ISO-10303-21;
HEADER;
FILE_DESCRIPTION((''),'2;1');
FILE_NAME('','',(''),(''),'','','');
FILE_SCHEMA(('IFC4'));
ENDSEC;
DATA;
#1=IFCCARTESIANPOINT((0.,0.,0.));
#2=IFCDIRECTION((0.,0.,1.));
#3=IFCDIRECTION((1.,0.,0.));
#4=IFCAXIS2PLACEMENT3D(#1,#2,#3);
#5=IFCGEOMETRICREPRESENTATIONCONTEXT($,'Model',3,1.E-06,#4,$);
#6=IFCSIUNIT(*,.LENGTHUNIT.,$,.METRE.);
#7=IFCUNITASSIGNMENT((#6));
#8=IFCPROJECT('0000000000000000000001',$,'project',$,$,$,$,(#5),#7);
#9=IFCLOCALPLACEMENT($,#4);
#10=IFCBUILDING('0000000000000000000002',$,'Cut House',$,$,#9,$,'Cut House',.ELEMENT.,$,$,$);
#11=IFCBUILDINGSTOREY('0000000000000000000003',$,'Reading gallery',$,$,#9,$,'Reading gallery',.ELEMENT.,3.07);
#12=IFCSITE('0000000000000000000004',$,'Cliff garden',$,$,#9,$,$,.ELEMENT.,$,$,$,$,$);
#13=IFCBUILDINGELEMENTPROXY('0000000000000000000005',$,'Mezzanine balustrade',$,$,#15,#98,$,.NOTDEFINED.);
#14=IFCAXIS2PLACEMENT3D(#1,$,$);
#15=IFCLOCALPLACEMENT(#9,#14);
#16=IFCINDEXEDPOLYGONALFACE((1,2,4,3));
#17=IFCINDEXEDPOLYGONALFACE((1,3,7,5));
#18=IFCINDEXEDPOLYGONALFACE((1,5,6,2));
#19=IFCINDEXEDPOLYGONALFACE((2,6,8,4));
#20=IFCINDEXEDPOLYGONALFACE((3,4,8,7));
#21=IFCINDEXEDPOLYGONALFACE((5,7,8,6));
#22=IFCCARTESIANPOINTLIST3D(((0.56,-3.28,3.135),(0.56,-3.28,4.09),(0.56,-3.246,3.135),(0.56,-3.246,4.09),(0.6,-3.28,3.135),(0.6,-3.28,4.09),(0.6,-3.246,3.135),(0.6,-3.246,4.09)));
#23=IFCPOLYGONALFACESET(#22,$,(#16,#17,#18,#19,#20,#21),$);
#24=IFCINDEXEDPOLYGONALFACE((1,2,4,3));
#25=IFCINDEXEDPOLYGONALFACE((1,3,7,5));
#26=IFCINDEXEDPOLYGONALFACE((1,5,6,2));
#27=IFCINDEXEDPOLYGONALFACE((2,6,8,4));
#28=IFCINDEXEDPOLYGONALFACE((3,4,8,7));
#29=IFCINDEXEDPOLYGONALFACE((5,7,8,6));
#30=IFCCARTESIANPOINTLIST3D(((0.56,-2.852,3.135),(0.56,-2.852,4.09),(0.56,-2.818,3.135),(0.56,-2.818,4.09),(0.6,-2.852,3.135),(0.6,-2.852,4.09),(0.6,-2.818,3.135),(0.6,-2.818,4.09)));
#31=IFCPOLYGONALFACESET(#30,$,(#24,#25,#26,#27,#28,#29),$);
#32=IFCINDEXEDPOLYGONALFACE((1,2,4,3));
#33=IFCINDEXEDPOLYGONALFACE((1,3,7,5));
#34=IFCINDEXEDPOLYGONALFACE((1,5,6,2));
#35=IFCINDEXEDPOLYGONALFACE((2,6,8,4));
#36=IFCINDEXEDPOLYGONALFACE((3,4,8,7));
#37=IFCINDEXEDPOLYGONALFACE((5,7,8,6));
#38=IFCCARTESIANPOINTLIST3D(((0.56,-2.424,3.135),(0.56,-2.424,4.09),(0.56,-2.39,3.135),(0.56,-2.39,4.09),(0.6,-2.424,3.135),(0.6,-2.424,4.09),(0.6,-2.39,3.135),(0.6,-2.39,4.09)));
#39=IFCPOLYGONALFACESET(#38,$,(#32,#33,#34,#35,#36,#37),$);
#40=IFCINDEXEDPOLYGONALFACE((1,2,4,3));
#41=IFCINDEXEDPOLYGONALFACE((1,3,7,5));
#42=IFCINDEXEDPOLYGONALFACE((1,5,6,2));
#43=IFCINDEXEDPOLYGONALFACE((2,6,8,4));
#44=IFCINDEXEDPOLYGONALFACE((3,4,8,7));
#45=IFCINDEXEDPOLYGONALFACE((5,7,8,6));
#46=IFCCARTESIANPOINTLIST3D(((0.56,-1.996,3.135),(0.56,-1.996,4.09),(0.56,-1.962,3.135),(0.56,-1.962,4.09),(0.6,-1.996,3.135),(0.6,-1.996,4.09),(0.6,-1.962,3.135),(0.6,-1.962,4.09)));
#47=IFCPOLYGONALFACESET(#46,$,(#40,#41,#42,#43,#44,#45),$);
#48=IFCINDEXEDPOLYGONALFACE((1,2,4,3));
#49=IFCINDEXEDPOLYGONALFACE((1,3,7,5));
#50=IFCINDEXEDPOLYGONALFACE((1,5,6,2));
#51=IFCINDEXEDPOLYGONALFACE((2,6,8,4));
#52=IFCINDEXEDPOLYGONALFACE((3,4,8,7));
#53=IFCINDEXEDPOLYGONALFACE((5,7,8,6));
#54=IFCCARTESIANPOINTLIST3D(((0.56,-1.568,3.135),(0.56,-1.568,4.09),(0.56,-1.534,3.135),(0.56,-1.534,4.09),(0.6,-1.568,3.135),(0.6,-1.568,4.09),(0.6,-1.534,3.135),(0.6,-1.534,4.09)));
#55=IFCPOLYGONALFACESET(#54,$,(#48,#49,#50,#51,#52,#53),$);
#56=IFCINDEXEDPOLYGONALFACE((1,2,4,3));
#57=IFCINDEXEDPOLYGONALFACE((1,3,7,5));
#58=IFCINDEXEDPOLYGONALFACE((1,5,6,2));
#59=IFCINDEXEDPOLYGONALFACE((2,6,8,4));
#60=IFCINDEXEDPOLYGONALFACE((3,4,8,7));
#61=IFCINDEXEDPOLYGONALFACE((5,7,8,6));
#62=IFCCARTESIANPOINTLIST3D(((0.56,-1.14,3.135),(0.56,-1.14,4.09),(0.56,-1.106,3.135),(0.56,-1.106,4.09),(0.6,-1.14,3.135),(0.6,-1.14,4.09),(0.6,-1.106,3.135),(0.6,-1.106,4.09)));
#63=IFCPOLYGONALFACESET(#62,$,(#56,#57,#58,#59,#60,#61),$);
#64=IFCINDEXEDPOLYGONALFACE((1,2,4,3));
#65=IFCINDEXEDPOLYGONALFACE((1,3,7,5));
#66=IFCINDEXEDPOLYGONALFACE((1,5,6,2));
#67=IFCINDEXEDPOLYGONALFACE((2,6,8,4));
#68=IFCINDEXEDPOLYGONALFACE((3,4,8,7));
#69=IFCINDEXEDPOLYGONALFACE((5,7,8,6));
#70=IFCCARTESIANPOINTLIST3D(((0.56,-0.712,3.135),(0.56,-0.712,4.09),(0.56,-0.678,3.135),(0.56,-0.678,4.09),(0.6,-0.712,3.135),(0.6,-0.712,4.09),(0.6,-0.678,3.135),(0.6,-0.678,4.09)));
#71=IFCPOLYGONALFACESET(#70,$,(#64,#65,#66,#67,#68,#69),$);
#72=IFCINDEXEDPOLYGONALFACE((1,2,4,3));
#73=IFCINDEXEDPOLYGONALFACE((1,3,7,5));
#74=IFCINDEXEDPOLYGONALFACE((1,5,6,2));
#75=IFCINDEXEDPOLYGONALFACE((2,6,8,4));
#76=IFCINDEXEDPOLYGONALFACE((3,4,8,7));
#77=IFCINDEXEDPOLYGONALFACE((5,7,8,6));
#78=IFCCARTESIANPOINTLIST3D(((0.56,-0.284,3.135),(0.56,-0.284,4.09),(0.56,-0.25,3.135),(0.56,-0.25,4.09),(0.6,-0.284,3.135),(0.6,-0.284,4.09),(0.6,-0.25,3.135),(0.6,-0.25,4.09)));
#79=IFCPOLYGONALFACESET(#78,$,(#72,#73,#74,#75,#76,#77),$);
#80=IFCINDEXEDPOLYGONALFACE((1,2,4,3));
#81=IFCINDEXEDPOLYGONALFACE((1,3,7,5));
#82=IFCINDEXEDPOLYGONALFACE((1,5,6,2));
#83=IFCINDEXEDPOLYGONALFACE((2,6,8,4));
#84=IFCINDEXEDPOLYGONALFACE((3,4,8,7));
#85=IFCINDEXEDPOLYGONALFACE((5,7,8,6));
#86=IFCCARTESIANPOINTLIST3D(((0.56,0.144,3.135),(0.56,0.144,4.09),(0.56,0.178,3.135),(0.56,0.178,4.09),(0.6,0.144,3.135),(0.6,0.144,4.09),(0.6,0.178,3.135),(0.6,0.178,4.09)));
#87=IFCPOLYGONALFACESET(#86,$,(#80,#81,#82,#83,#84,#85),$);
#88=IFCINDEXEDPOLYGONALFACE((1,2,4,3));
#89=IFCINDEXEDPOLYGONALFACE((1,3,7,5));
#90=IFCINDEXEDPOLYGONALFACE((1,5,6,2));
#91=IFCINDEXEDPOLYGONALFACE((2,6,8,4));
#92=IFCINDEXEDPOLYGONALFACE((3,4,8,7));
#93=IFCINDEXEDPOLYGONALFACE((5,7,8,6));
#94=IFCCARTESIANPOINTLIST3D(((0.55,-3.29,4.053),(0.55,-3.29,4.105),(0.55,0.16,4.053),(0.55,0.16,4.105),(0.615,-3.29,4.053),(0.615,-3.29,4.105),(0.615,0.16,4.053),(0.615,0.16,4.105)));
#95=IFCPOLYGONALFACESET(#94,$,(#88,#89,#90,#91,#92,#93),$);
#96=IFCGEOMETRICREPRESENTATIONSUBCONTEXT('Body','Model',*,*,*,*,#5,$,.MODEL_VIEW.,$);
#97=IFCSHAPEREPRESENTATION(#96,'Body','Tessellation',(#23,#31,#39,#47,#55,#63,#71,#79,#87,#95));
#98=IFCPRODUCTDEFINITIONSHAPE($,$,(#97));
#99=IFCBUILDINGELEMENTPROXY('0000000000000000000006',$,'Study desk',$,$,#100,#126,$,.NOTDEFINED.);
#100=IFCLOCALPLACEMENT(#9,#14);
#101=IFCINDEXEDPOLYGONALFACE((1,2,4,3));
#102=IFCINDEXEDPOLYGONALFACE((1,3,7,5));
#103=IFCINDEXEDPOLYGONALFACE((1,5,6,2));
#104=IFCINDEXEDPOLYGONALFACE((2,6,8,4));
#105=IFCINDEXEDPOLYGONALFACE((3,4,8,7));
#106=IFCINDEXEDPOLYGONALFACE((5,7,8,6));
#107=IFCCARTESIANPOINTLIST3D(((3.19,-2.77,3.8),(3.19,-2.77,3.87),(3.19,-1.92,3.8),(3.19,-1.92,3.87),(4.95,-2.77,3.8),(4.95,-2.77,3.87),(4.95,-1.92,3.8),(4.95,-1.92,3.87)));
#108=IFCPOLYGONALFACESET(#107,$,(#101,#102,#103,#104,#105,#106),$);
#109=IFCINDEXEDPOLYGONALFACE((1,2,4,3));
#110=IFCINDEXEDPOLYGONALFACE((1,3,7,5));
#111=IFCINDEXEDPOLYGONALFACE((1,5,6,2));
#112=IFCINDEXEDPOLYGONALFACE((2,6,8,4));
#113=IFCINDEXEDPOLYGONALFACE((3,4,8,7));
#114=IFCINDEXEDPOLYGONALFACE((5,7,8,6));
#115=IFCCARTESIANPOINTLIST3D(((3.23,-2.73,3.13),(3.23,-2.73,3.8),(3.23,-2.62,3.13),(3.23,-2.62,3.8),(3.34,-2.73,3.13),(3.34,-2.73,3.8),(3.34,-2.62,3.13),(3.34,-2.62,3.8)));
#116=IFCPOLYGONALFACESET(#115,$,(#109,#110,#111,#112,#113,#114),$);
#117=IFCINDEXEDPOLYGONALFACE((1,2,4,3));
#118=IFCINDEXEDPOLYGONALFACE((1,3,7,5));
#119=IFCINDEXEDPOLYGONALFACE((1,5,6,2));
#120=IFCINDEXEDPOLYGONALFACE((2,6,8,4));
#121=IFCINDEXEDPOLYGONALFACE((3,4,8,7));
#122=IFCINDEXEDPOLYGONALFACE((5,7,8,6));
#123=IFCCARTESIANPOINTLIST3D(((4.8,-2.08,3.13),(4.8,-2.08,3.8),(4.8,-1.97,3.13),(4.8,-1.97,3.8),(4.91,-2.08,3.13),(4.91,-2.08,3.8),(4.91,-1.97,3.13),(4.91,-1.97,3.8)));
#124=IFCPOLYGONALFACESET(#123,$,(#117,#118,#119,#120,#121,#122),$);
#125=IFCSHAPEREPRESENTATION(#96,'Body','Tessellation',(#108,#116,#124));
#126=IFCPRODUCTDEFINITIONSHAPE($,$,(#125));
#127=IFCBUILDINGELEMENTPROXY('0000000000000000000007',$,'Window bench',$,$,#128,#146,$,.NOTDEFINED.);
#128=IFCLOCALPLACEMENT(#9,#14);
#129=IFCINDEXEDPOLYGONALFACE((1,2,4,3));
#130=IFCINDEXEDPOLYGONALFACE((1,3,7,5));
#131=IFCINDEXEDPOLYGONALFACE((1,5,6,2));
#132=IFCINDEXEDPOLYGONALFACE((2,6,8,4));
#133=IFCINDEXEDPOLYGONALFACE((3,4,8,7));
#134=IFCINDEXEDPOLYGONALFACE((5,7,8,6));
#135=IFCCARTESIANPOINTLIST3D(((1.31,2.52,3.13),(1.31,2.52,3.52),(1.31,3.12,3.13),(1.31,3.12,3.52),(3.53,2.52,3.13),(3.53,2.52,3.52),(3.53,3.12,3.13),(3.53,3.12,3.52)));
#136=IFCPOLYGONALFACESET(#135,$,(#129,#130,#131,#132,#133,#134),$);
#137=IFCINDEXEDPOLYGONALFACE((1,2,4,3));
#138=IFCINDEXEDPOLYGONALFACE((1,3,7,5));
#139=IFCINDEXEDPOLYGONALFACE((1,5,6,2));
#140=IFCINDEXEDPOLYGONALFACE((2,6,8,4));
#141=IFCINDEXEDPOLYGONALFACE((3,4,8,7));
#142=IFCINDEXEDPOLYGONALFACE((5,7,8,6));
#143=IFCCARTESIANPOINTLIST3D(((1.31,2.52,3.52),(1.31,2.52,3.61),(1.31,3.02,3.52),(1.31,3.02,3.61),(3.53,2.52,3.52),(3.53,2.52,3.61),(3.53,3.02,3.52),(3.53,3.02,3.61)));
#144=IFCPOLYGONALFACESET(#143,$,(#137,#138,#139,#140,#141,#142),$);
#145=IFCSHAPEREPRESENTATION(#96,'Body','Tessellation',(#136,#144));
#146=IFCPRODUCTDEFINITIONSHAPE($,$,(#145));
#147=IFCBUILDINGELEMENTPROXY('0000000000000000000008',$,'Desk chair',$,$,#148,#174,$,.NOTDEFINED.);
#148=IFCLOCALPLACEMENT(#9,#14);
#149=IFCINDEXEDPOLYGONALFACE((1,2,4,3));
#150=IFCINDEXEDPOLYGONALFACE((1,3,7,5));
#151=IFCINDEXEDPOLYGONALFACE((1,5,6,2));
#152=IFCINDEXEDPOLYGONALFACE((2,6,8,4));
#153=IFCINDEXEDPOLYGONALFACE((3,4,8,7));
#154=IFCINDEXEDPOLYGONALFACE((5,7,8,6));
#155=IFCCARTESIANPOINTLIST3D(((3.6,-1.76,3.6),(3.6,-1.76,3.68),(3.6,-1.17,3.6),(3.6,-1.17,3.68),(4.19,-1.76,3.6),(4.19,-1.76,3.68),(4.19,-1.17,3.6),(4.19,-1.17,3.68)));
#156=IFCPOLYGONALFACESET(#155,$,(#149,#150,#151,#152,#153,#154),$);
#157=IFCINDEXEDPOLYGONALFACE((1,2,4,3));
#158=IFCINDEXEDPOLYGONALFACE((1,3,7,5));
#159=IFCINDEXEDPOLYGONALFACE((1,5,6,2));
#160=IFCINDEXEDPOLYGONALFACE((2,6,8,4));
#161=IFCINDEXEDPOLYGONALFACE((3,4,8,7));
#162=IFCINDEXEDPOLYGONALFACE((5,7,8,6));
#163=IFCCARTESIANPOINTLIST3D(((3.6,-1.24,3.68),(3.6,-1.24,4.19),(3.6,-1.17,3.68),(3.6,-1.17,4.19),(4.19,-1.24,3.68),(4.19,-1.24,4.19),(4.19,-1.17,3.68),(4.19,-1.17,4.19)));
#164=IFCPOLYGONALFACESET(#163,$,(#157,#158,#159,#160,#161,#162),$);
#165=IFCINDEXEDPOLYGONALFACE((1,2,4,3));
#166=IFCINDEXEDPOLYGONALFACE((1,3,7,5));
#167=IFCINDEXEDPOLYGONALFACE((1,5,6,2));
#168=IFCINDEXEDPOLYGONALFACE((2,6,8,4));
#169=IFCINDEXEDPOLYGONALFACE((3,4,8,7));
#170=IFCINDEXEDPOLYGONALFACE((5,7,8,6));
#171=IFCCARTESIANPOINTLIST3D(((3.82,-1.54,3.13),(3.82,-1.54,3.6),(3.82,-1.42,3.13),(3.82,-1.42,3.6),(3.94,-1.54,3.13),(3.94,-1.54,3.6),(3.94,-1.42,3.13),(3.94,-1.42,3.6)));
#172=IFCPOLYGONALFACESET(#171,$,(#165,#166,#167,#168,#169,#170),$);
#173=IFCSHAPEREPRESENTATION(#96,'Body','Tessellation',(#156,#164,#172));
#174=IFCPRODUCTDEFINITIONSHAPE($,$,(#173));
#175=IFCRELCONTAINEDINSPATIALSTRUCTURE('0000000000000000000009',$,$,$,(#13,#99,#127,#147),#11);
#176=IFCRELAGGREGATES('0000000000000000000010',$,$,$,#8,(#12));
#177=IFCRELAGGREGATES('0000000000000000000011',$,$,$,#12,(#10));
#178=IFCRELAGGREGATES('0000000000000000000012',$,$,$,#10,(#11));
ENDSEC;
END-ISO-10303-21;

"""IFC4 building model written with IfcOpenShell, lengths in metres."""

from ifc_helpers import new_model, si_unit, frame, origin_with_axes, place, context, subcontext, project, spatial, polyline, outline, extrude, element, save


model = new_model("IFC4")

# Units and contexts
model_context = context("Model", 3, precision=1e-06, world=origin_with_axes())
body_context = subcontext(model_context, "Body", "Model", "MODEL_VIEW")
ifc_project = project(units=[si_unit("LENGTHUNIT", "METRE")], contexts=[model_context])

# Site, building, storey
placement = place(None, origin_with_axes())
site = spatial("IfcSite", under=ifc_project, at=placement, Name="Cliff garden", CompositionType="ELEMENT")
building = spatial("IfcBuilding", under=site, at=placement, Name="Cut House", LongName="Cut House", CompositionType="ELEMENT")
storey = spatial("IfcBuildingStorey", under=building, at=placement, Name="Reading gallery", LongName="Reading gallery", CompositionType="ELEMENT", Elevation=3.07)

# Building element proxies
element("IfcBuildingElementProxy", 1, at=placement, inside=storey, Name="Mezzanine balustrade", PredefinedType="NOTDEFINED", context=body_context, shape_type="SweptSolid", body=[
    extrude(outline(polyline([(0.0, 0.0), (0.04, 0.0), (0.04, 0.034), (0.0, 0.034), (0.0, 0.0)])), frame((0.56, -3.28, 3.135), z_axis=(0.0, 0.0, 1.0), x_axis=(1.0, 0.0, 0.0)), (0.0, 0.0, 1.0), 0.955),
    extrude(outline(polyline([(0.0, 0.0), (0.04, 0.0), (0.04, 0.034), (0.0, 0.034), (0.0, 0.0)])), frame((0.56, -2.852, 3.135), z_axis=(0.0, 0.0, 1.0), x_axis=(1.0, 0.0, 0.0)), (0.0, 0.0, 1.0), 0.955),
    extrude(outline(polyline([(0.0, 0.0), (0.04, 0.0), (0.04, 0.034), (0.0, 0.034), (0.0, 0.0)])), frame((0.56, -2.424, 3.135), z_axis=(0.0, 0.0, 1.0), x_axis=(1.0, 0.0, 0.0)), (0.0, 0.0, 1.0), 0.955),
    extrude(outline(polyline([(0.0, 0.0), (0.04, 0.0), (0.04, 0.034), (0.0, 0.034), (0.0, 0.0)])), frame((0.56, -1.996, 3.135), z_axis=(0.0, 0.0, 1.0), x_axis=(1.0, 0.0, 0.0)), (0.0, 0.0, 1.0), 0.955),
    extrude(outline(polyline([(0.0, 0.0), (0.04, 0.0), (0.04, 0.034), (0.0, 0.034), (0.0, 0.0)])), frame((0.56, -1.568, 3.135), z_axis=(0.0, 0.0, 1.0), x_axis=(1.0, 0.0, 0.0)), (0.0, 0.0, 1.0), 0.955),
    extrude(outline(polyline([(0.0, 0.0), (0.04, 0.0), (0.04, 0.034), (0.0, 0.034), (0.0, 0.0)])), frame((0.56, -1.14, 3.135), z_axis=(0.0, 0.0, 1.0), x_axis=(1.0, 0.0, 0.0)), (0.0, 0.0, 1.0), 0.955),
    extrude(outline(polyline([(0.0, 0.0), (0.04, 0.0), (0.04, 0.034), (0.0, 0.034), (0.0, 0.0)])), frame((0.56, -0.712, 3.135), z_axis=(0.0, 0.0, 1.0), x_axis=(1.0, 0.0, 0.0)), (0.0, 0.0, 1.0), 0.955),
    extrude(outline(polyline([(0.0, 0.0), (0.04, 0.0), (0.04, 0.034), (0.0, 0.034), (0.0, 0.0)])), frame((0.56, -0.284, 3.135), z_axis=(0.0, 0.0, 1.0), x_axis=(1.0, 0.0, 0.0)), (0.0, 0.0, 1.0), 0.955),
    extrude(outline(polyline([(0.0, 0.0), (0.04, 0.0), (0.04, 0.034), (0.0, 0.034), (0.0, 0.0)])), frame((0.56, 0.144, 3.135), z_axis=(0.0, 0.0, 1.0), x_axis=(1.0, 0.0, 0.0)), (0.0, 0.0, 1.0), 0.955),
    extrude(outline(polyline([(0.0, 0.0), (0.065, 0.0), (0.065, 3.45), (0.0, 3.45), (0.0, 0.0)])), frame((0.55, -3.29, 4.053), z_axis=(0.0, 0.0, 1.0), x_axis=(1.0, 0.0, 0.0)), (0.0, 0.0, 1.0), 0.052),
])
element("IfcBuildingElementProxy", 2, at=placement, inside=storey, Name="Study desk", PredefinedType="NOTDEFINED", context=body_context, shape_type="SweptSolid", body=[
    extrude(outline(polyline([(0.0, 0.0), (1.76, 0.0), (1.76, 0.85), (0.0, 0.85), (0.0, 0.0)])), frame((3.19, -2.77, 3.8), z_axis=(0.0, 0.0, 1.0), x_axis=(1.0, 0.0, 0.0)), (0.0, 0.0, 1.0), 0.07),
    extrude(outline(polyline([(0.0, 0.0), (0.11, 0.0), (0.11, 0.11), (0.0, 0.11), (0.0, 0.0)])), frame((3.23, -2.73, 3.13), z_axis=(0.0, 0.0, 1.0), x_axis=(1.0, 0.0, 0.0)), (0.0, 0.0, 1.0), 0.67),
    extrude(outline(polyline([(0.0, 0.0), (0.11, 0.0), (0.11, 0.11), (0.0, 0.11), (0.0, 0.0)])), frame((4.8, -2.08, 3.13), z_axis=(0.0, 0.0, 1.0), x_axis=(1.0, 0.0, 0.0)), (0.0, 0.0, 1.0), 0.67),
])
element("IfcBuildingElementProxy", 3, at=placement, inside=storey, Name="Window bench", PredefinedType="NOTDEFINED", context=body_context, shape_type="SweptSolid", body=[
    extrude(outline(polyline([(0.0, 0.0), (2.22, 0.0), (2.22, 0.6), (0.0, 0.6), (0.0, 0.0)])), frame((1.31, 2.52, 3.13), z_axis=(0.0, 0.0, 1.0), x_axis=(1.0, 0.0, 0.0)), (0.0, 0.0, 1.0), 0.39),
    extrude(outline(polyline([(0.0, 0.0), (2.22, 0.0), (2.22, 0.5), (0.0, 0.5), (0.0, 0.0)])), frame((1.31, 2.52, 3.52), z_axis=(0.0, 0.0, 1.0), x_axis=(1.0, 0.0, 0.0)), (0.0, 0.0, 1.0), 0.09),
])
element("IfcBuildingElementProxy", 4, at=placement, inside=storey, Name="Desk chair", PredefinedType="NOTDEFINED", context=body_context, shape_type="SweptSolid", body=[
    extrude(outline(polyline([(0.0, 0.0), (0.59, 0.0), (0.59, 0.59), (0.0, 0.59), (0.0, 0.0)])), frame((3.6, -1.76, 3.6), z_axis=(0.0, 0.0, 1.0), x_axis=(1.0, 0.0, 0.0)), (0.0, 0.0, 1.0), 0.08),
    extrude(outline(polyline([(0.0, 0.0), (0.59, 0.0), (0.59, 0.07), (0.0, 0.07), (0.0, 0.0)])), frame((3.6, -1.24, 3.68), z_axis=(0.0, 0.0, 1.0), x_axis=(1.0, 0.0, 0.0)), (0.0, 0.0, 1.0), 0.51),
    extrude(outline(polyline([(0.0, 0.0), (0.12, 0.0), (0.12, 0.12), (0.0, 0.12), (0.0, 0.0)])), frame((3.82, -1.54, 3.13), z_axis=(0.0, 0.0, 1.0), x_axis=(1.0, 0.0, 0.0)), (0.0, 0.0, 1.0), 0.47),
])

save(model, "model.ifc")
